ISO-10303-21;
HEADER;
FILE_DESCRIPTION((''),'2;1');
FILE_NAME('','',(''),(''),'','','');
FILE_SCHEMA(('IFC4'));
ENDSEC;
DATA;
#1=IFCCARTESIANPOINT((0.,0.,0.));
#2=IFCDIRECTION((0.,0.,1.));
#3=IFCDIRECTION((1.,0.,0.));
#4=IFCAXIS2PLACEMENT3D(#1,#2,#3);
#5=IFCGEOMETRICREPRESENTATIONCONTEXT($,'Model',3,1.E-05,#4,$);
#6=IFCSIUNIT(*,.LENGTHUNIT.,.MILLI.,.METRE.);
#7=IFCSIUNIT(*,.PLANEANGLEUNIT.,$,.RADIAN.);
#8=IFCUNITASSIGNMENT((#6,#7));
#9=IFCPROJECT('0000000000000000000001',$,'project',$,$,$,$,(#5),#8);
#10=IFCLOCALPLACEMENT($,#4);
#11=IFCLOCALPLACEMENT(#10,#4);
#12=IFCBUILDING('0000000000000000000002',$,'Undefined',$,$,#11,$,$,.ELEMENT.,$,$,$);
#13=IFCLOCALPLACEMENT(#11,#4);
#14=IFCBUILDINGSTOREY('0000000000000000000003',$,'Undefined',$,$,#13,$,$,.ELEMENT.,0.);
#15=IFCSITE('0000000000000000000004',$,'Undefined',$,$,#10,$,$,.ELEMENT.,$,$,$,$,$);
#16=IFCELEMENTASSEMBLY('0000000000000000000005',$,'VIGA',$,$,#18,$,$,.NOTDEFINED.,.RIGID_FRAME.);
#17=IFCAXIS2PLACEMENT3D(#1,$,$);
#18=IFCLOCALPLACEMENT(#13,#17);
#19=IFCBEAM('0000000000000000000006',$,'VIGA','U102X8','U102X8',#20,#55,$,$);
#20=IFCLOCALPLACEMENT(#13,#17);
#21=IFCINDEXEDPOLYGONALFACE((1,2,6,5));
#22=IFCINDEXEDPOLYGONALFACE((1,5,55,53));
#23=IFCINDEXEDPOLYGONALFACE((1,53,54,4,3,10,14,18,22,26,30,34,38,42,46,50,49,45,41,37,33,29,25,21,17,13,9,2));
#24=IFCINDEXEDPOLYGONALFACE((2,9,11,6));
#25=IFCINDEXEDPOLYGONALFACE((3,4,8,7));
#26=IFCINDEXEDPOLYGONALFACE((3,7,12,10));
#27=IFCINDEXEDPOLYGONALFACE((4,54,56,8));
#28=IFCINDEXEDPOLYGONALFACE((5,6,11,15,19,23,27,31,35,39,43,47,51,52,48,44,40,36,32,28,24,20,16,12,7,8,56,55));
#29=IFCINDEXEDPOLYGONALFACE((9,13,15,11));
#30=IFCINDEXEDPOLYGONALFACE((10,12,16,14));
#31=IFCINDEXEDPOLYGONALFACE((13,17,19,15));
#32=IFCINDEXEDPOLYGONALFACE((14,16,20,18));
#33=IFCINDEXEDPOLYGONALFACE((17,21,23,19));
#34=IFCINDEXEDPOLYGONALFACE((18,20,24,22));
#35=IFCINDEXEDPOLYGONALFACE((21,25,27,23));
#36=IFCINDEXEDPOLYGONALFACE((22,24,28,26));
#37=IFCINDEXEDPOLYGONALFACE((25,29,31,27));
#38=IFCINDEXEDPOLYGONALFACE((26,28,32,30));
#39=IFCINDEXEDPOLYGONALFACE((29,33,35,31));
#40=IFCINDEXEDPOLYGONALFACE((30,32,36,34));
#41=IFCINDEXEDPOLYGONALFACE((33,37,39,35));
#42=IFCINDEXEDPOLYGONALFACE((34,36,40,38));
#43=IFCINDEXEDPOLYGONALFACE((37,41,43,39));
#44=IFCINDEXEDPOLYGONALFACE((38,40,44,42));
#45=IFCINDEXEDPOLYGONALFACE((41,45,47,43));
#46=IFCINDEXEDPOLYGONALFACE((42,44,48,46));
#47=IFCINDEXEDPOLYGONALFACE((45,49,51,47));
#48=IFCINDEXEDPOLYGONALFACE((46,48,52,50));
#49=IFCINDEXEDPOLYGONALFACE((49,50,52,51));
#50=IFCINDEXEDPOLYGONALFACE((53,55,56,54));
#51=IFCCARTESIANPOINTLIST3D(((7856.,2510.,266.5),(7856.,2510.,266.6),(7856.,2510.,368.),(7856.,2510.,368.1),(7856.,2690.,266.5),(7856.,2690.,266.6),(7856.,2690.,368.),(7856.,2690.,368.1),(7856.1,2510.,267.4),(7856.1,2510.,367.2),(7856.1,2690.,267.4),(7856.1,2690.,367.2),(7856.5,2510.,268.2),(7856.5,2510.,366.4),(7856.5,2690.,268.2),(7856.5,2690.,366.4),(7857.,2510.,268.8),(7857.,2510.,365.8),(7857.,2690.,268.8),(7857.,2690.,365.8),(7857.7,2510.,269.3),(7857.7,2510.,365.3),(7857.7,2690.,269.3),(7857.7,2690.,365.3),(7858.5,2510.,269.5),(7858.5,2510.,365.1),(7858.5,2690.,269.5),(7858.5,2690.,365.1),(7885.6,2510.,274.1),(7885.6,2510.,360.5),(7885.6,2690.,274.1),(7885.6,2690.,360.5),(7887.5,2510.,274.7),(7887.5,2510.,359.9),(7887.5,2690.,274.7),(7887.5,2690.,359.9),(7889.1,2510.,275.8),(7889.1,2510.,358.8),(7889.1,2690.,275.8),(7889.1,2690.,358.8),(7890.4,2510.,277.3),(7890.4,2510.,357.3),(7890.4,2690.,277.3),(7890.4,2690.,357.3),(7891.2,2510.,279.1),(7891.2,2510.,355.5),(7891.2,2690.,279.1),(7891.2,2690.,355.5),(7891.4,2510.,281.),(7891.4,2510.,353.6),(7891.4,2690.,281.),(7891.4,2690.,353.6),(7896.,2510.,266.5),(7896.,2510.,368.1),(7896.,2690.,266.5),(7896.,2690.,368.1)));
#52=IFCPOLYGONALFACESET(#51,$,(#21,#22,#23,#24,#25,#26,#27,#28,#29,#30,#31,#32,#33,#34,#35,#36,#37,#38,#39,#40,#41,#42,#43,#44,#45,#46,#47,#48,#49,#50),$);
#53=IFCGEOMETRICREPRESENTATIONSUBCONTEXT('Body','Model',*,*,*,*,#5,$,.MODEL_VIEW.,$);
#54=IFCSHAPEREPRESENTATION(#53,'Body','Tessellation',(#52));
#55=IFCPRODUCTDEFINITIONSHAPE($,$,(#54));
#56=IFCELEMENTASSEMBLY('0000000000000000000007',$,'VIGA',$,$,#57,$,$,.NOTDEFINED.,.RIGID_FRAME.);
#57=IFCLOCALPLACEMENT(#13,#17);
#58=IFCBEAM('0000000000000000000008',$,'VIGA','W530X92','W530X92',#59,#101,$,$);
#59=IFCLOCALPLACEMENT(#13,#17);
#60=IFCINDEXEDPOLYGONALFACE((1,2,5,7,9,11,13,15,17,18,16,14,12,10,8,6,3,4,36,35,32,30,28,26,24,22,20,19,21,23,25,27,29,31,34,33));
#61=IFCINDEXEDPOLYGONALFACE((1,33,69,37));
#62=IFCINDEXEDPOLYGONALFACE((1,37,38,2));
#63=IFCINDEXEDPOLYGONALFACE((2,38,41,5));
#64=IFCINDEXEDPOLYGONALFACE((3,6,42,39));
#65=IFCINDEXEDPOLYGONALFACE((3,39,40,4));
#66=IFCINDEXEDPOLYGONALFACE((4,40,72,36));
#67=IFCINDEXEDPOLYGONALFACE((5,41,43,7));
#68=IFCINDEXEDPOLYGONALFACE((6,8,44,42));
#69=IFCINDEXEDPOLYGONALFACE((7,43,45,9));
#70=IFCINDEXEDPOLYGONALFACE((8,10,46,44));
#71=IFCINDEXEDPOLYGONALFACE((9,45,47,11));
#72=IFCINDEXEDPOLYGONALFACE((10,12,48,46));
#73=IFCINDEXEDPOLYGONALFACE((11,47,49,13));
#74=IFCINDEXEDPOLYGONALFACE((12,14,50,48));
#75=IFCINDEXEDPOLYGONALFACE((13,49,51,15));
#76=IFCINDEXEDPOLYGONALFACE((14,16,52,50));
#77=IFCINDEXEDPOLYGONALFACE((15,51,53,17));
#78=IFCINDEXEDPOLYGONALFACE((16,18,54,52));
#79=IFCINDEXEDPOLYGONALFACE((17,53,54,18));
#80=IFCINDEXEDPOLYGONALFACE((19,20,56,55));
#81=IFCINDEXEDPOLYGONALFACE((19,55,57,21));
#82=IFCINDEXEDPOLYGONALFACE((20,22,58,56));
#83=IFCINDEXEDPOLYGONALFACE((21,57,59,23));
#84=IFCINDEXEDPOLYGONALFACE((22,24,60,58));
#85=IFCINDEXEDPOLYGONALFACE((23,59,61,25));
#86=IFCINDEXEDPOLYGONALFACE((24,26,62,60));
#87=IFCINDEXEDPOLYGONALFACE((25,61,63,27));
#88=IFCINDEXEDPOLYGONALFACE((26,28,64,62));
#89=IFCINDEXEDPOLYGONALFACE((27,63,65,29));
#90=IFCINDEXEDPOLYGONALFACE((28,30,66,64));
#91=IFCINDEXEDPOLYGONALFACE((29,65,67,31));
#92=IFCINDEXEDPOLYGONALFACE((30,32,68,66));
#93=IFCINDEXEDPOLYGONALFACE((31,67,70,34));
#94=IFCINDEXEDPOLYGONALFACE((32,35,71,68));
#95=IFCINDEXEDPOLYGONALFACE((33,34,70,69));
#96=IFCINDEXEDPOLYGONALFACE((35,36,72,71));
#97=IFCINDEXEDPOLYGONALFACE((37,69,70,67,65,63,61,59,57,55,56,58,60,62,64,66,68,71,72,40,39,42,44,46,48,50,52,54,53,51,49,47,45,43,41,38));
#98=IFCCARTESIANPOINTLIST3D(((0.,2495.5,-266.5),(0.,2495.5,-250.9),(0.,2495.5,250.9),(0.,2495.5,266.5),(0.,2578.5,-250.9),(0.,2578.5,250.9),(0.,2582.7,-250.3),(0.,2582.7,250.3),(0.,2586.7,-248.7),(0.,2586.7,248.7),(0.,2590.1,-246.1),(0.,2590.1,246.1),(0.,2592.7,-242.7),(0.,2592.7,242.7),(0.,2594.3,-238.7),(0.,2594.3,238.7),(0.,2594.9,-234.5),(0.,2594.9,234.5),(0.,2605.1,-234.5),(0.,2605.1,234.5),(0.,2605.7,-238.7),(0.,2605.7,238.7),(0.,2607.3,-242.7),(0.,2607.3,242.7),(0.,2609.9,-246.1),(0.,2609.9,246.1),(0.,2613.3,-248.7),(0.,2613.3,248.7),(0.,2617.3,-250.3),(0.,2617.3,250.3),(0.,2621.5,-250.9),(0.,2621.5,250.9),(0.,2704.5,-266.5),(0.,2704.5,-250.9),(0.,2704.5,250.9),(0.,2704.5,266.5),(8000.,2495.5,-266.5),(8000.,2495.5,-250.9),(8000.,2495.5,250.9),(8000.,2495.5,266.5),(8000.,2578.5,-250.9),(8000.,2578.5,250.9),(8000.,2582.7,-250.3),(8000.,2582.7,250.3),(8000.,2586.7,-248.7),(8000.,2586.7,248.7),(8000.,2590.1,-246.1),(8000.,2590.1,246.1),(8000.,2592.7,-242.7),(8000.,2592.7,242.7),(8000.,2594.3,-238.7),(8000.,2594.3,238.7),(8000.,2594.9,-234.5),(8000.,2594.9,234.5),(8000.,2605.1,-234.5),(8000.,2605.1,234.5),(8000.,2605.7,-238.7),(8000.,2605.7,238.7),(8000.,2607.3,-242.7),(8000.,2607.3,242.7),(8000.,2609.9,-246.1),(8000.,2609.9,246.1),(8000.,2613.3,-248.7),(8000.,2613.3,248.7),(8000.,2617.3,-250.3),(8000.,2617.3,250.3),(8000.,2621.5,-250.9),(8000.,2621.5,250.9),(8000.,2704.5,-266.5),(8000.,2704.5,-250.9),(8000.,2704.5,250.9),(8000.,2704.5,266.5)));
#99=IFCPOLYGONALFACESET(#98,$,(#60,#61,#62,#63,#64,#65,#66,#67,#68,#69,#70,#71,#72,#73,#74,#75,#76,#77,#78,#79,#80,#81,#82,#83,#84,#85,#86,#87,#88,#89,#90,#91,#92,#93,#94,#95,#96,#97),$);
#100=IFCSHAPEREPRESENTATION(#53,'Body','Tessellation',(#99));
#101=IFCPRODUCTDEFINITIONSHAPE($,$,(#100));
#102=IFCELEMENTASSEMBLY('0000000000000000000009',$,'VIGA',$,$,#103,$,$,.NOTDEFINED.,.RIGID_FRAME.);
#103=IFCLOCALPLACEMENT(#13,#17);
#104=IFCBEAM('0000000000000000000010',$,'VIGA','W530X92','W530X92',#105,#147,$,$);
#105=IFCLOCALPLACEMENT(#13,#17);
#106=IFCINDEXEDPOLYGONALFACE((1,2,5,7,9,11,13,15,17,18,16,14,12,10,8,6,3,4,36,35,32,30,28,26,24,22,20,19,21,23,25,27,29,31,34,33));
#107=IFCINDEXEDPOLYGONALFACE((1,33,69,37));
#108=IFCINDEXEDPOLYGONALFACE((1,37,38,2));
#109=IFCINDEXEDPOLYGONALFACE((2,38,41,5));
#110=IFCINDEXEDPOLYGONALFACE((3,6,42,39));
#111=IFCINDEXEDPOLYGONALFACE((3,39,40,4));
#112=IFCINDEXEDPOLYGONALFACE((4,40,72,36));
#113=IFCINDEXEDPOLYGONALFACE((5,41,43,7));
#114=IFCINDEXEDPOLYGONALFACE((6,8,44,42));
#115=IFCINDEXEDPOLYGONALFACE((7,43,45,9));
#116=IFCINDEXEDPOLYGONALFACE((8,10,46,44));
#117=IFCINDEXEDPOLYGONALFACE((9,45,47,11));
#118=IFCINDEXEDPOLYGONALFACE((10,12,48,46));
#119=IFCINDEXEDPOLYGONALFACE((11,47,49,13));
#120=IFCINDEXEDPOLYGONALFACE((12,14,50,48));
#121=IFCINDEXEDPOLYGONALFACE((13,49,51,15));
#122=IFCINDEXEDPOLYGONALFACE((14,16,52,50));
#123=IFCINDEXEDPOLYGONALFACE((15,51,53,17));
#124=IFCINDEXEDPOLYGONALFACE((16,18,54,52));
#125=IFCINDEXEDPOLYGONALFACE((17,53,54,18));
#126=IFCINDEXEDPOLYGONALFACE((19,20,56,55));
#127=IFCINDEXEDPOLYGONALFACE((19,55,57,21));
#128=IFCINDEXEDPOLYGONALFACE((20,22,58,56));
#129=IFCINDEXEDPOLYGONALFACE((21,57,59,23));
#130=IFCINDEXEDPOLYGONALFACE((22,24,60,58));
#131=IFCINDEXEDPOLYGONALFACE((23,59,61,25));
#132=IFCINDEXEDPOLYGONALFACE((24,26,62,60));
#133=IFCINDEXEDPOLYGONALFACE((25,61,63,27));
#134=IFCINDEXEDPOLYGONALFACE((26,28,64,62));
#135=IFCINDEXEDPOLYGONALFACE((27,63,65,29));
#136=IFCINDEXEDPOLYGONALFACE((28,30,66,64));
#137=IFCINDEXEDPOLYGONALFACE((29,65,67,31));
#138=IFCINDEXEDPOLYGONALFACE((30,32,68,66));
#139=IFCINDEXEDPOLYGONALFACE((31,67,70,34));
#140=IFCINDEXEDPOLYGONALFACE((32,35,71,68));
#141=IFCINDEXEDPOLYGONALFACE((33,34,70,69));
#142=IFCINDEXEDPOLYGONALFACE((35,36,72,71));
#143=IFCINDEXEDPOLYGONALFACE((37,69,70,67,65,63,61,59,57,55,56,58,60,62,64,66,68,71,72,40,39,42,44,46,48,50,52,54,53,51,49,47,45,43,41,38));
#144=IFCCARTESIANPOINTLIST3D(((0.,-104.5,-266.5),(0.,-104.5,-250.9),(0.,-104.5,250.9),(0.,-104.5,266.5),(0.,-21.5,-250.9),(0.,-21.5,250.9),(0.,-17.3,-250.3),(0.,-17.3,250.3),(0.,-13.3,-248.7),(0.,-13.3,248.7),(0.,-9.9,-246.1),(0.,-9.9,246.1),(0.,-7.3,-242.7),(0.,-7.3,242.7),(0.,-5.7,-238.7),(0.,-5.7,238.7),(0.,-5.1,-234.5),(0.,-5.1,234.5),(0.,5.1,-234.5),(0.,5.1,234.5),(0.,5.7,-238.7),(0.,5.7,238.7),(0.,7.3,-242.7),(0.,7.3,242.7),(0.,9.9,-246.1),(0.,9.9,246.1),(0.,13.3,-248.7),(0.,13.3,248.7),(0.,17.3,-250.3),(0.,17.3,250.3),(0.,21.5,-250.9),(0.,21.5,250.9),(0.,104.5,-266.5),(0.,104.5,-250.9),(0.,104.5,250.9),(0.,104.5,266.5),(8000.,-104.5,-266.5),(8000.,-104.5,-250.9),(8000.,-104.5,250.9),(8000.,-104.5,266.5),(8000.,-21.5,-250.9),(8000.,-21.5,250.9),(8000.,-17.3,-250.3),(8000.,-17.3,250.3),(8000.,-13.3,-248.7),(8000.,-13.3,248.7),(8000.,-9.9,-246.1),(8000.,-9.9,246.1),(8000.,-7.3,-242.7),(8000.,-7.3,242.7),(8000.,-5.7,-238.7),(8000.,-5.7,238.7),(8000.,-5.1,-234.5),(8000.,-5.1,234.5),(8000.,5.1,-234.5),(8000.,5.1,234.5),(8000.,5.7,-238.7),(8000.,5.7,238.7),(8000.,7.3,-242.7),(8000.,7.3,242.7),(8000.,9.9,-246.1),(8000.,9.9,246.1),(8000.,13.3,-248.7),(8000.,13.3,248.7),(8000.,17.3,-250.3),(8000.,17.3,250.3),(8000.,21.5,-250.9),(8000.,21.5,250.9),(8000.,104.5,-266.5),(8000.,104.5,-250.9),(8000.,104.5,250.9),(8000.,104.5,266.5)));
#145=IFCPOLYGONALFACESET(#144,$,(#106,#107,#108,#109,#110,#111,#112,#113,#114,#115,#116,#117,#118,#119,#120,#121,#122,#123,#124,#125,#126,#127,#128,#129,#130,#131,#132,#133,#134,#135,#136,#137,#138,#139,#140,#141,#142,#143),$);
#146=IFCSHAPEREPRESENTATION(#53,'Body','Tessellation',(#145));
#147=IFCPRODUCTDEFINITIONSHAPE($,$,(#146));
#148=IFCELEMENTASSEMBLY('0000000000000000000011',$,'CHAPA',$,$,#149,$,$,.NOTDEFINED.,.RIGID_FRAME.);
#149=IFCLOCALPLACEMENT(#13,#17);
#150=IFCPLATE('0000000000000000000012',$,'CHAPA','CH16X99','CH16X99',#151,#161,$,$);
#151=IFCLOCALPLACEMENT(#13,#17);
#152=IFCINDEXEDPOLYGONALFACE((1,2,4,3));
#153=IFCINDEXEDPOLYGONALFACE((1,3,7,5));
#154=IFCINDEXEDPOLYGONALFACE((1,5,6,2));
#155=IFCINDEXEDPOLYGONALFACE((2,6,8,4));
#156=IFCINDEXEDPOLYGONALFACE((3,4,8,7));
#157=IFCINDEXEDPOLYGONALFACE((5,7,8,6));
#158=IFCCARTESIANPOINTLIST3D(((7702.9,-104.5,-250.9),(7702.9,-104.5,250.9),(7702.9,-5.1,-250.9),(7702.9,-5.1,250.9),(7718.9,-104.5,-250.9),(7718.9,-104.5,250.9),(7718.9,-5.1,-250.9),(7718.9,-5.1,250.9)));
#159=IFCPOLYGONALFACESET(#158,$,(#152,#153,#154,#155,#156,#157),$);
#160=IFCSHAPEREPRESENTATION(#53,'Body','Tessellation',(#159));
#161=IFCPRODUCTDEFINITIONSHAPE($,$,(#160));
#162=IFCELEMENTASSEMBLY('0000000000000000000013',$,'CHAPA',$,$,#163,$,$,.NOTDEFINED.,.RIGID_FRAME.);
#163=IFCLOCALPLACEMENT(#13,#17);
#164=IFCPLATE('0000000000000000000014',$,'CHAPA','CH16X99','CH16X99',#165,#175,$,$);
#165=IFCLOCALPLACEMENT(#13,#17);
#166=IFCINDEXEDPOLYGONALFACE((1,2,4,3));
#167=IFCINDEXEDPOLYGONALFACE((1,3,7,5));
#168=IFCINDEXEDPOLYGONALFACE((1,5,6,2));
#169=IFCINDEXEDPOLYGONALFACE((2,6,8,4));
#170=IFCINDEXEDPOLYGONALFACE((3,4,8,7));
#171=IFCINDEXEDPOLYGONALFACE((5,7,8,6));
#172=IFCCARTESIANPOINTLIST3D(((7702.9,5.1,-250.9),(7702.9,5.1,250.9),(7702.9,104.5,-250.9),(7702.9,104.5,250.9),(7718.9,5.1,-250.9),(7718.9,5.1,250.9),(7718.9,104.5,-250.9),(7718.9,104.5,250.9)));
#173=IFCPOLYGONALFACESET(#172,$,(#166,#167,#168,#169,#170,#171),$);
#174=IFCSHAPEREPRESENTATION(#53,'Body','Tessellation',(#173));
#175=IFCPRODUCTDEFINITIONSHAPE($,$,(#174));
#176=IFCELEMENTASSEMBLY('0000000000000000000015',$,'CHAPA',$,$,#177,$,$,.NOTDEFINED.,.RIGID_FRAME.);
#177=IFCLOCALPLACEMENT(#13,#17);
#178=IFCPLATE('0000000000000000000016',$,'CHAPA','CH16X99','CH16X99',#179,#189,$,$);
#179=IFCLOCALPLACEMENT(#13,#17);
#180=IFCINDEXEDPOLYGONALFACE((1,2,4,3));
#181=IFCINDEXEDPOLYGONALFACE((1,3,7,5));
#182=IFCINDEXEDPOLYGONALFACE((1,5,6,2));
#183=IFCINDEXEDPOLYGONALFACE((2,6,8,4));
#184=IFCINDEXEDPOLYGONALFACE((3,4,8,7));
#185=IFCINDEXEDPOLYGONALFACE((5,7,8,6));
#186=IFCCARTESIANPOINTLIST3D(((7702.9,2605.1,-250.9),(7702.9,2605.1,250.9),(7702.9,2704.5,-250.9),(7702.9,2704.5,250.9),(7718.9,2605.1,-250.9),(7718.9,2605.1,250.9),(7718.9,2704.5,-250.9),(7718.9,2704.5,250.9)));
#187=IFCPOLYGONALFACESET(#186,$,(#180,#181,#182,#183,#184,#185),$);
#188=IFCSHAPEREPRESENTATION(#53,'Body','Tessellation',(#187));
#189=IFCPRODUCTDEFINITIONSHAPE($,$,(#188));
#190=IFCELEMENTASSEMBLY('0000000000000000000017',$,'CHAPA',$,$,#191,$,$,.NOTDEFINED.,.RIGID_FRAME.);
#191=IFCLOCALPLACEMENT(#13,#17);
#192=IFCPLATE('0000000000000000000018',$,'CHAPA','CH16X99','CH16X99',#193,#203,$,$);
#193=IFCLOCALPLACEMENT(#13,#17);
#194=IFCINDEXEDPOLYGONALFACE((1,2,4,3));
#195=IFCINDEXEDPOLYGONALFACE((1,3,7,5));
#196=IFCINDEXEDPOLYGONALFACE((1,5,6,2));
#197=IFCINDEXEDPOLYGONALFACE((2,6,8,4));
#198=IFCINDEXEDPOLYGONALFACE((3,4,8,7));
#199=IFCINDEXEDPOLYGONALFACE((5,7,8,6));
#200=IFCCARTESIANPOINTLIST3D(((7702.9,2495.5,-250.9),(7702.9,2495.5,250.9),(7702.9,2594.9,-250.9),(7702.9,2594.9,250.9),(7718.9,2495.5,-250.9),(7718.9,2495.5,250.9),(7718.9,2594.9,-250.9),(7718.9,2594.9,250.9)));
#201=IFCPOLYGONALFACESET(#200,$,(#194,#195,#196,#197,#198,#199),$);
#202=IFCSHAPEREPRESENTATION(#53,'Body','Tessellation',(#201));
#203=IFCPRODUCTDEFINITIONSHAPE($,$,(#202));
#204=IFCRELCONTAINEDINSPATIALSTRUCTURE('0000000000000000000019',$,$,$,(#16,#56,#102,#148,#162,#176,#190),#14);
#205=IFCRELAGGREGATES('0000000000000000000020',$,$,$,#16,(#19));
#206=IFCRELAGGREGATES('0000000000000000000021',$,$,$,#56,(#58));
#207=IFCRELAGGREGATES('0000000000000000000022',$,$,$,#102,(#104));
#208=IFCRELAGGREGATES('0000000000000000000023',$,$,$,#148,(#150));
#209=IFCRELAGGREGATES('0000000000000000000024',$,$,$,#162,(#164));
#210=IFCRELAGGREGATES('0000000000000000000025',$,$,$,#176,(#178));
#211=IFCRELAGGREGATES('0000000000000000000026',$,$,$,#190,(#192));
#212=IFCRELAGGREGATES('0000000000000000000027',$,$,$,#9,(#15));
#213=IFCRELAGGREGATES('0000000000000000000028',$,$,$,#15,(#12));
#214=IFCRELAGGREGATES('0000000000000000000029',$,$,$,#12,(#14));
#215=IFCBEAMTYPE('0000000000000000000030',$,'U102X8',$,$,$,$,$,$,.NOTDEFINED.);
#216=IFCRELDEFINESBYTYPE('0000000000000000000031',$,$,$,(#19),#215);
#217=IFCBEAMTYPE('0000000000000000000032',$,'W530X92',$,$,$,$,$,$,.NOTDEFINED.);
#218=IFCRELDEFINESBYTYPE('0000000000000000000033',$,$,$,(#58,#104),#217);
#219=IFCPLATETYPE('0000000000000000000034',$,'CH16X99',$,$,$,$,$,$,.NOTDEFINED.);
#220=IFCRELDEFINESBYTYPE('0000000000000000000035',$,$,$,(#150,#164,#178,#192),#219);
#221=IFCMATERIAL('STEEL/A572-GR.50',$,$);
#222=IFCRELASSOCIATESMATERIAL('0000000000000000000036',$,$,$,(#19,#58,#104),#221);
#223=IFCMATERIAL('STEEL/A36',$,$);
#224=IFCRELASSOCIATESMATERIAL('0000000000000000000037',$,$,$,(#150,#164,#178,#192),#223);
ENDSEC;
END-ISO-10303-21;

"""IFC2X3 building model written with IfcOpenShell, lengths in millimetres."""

from ifc_helpers import new_model, si_unit, frame, origin_with_axes, origin_2d_with_axis, place, context, subcontext, project, spatial, polyline, i_section, u_section, outline, extrude, material, type_object, element, aggregate, save


model = new_model("IFC2X3")

# Units and contexts
model_context = context("Model", 3, precision=1e-05, world=origin_with_axes())
body_context = subcontext(model_context, "Body", "Model", "MODEL_VIEW")
ifc_project = project(units=[si_unit("LENGTHUNIT", "METRE", prefix="MILLI"), si_unit("PLANEANGLEUNIT", "RADIAN")], contexts=[model_context])

# Site, building, storey
site_placement = place(None, origin_with_axes())
site = spatial("IfcSite", under=ifc_project, at=site_placement, Name="Undefined", CompositionType="ELEMENT")
building_placement = place(site_placement, origin_with_axes())
building = spatial("IfcBuilding", under=site, at=building_placement, Name="Undefined", CompositionType="ELEMENT")
storey_placement = place(building_placement, origin_with_axes())
storey = spatial("IfcBuildingStorey", under=building, at=storey_placement, Name="Undefined", CompositionType="ELEMENT", Elevation=0.0)

# Element assemblies, beams
ifc_material_1 = material(Name="STEEL/A572-GR.50")
beam_type_1 = type_object("IfcBeamType", Name="U102X8", PredefinedType="NOTDEFINED")
assembly_1_placement = place(storey_placement, origin_with_axes())
assembly_1 = element("IfcElementAssembly", 1, at=assembly_1_placement, inside=storey, Name="VIGA", AssemblyPlace="NOTDEFINED", PredefinedType="RIGID_FRAME")
beam_1_placement = place(assembly_1_placement, frame((7876.0, 2690.0, 317.3), z_axis=(0.0, 0.0, 1.0), x_axis=(0.0, -1.0, 0.0)))
beam_1 = element("IfcBeam", 2, at=beam_1_placement, type_object=beam_type_1, material=ifc_material_1, Name="VIGA", Description="U102X8", ObjectType="U102X8", context=body_context, shape_type="SweptSolid", body=[
    extrude(u_section(Depth=101.6, FlangeWidth=40.0, WebThickness=4.6, FlangeThickness=6.0, FilletRadius=7.0, EdgeRadius=3.0, FlangeSlope=0.16839, at=origin_2d_with_axis()), frame((180.0, 0.0, 0.0), z_axis=(-1.0, 0.0, 0.0), x_axis=(0.0, -1.0, 0.0)), (0.0, 0.0, 1.0), 180.0),
])
aggregate(assembly_1, [beam_1])
assembly_2_placement = place(storey_placement, origin_with_axes())
assembly_2 = element("IfcElementAssembly", 3, at=assembly_2_placement, inside=storey, Name="VIGA", AssemblyPlace="NOTDEFINED", PredefinedType="RIGID_FRAME")
beam_type_2 = type_object("IfcBeamType", Name="W530X92", PredefinedType="NOTDEFINED")
beam_2_placement = place(assembly_2_placement, frame((8000.0, 2600.0, 0.0), z_axis=(0.0, 0.0, 1.0), x_axis=(-1.0, 0.0, 0.0)))
beam_2 = element("IfcBeam", 4, at=beam_2_placement, type_object=beam_type_2, material=ifc_material_1, Name="VIGA", Description="W530X92", ObjectType="W530X92", context=body_context, shape_type="SweptSolid", body=[
    extrude(i_section(OverallWidth=209.0, OverallDepth=533.0, WebThickness=10.2, FlangeThickness=15.6, FilletRadius=16.4, at=origin_2d_with_axis()), frame((8000.0, 0.0, 0.0), z_axis=(-1.0, 0.0, 0.0), x_axis=(0.0, -1.0, 0.0)), (0.0, 0.0, 1.0), 8000.0),
])
aggregate(assembly_2, [beam_2])
assembly_3_placement = place(storey_placement, origin_with_axes())
assembly_3 = element("IfcElementAssembly", 5, at=assembly_3_placement, inside=storey, Name="VIGA", AssemblyPlace="NOTDEFINED", PredefinedType="RIGID_FRAME")
beam_3_placement = place(assembly_3_placement, frame((8000.0, 0.0, 0.0), z_axis=(0.0, 0.0, 1.0), x_axis=(-1.0, 0.0, 0.0)))
beam_3 = element("IfcBeam", 6, at=beam_3_placement, type_object=beam_type_2, material=ifc_material_1, Name="VIGA", Description="W530X92", ObjectType="W530X92", context=body_context, shape_type="SweptSolid", body=[
    extrude(i_section(OverallWidth=209.0, OverallDepth=533.0, WebThickness=10.2, FlangeThickness=15.6, FilletRadius=16.4, at=origin_2d_with_axis()), frame((8000.0, 0.0, 0.0), z_axis=(-1.0, 0.0, 0.0), x_axis=(0.0, -1.0, 0.0)), (0.0, 0.0, 1.0), 8000.0),
])
aggregate(assembly_3, [beam_3])

# Element assemblies, plates
assembly_4_placement = place(storey_placement, origin_with_axes())
assembly_4 = element("IfcElementAssembly", 7, at=assembly_4_placement, inside=storey, Name="CHAPA", AssemblyPlace="NOTDEFINED", PredefinedType="RIGID_FRAME")
ifc_material_2 = material(Name="STEEL/A36")
plate_type = type_object("IfcPlateType", Name="CH16X99", PredefinedType="NOTDEFINED")
plate_1_placement = place(assembly_4_placement, frame((7710.9, -104.5, 250.9), z_axis=(-1.0, 0.0, 0.0), x_axis=(0.0, 1.0, 0.0)))
plate_1 = element("IfcPlate", 8, at=plate_1_placement, type_object=plate_type, material=ifc_material_2, Name="CHAPA", Description="CH16X99", ObjectType="CH16X99", context=body_context, shape_type="SweptSolid", body=[
    extrude(outline(polyline([(0.0, 0.0), (99.4, 0.0), (99.4, 501.8), (0.0, 501.8), (0.0, 0.0)])), frame((0.0, 0.0, -8.0), z_axis=(0.0, 0.0, 1.0), x_axis=(1.0, 0.0, 0.0)), (0.0, 0.0, 1.0), 16.0),
])
aggregate(assembly_4, [plate_1])
assembly_5_placement = place(storey_placement, origin_with_axes())
assembly_5 = element("IfcElementAssembly", 9, at=assembly_5_placement, inside=storey, Name="CHAPA", AssemblyPlace="NOTDEFINED", PredefinedType="RIGID_FRAME")
plate_2_placement = place(assembly_5_placement, frame((7710.9, 5.1, 250.9), z_axis=(-1.0, 0.0, 0.0), x_axis=(0.0, 1.0, 0.0)))
plate_2 = element("IfcPlate", 10, at=plate_2_placement, type_object=plate_type, material=ifc_material_2, Name="CHAPA", Description="CH16X99", ObjectType="CH16X99", context=body_context, shape_type="SweptSolid", body=[
    extrude(outline(polyline([(0.0, 0.0), (99.4, 0.0), (99.4, 501.8), (0.0, 501.8), (0.0, 0.0)])), frame((0.0, 0.0, -8.0), z_axis=(0.0, 0.0, 1.0), x_axis=(1.0, 0.0, 0.0)), (0.0, 0.0, 1.0), 16.0),
])
aggregate(assembly_5, [plate_2])
assembly_6_placement = place(storey_placement, origin_with_axes())
assembly_6 = element("IfcElementAssembly", 11, at=assembly_6_placement, inside=storey, Name="CHAPA", AssemblyPlace="NOTDEFINED", PredefinedType="RIGID_FRAME")
plate_3_placement = place(assembly_6_placement, frame((7710.9, 2605.1, 250.9), z_axis=(-1.0, 0.0, 0.0), x_axis=(0.0, 1.0, 0.0)))
plate_3 = element("IfcPlate", 12, at=plate_3_placement, type_object=plate_type, material=ifc_material_2, Name="CHAPA", Description="CH16X99", ObjectType="CH16X99", context=body_context, shape_type="SweptSolid", body=[
    extrude(outline(polyline([(0.0, 0.0), (99.4, 0.0), (99.4, 501.8), (0.0, 501.8), (0.0, 0.0)])), frame((0.0, 0.0, -8.0), z_axis=(0.0, 0.0, 1.0), x_axis=(1.0, 0.0, 0.0)), (0.0, 0.0, 1.0), 16.0),
])
aggregate(assembly_6, [plate_3])
assembly_7_placement = place(storey_placement, origin_with_axes())
assembly_7 = element("IfcElementAssembly", 13, at=assembly_7_placement, inside=storey, Name="CHAPA", AssemblyPlace="NOTDEFINED", PredefinedType="RIGID_FRAME")
plate_4_placement = place(assembly_7_placement, frame((7710.9, 2495.5, 250.9), z_axis=(-1.0, 0.0, 0.0), x_axis=(0.0, 1.0, 0.0)))
plate_4 = element("IfcPlate", 14, at=plate_4_placement, type_object=plate_type, material=ifc_material_2, Name="CHAPA", Description="CH16X99", ObjectType="CH16X99", context=body_context, shape_type="SweptSolid", body=[
    extrude(outline(polyline([(0.0, 0.0), (99.4, 0.0), (99.4, 501.8), (0.0, 501.8), (0.0, 0.0)])), frame((0.0, 0.0, -8.0), z_axis=(0.0, 0.0, 1.0), x_axis=(1.0, 0.0, 0.0)), (0.0, 0.0, 1.0), 16.0),
])
aggregate(assembly_7, [plate_4])

save(model, "model.ifc")
